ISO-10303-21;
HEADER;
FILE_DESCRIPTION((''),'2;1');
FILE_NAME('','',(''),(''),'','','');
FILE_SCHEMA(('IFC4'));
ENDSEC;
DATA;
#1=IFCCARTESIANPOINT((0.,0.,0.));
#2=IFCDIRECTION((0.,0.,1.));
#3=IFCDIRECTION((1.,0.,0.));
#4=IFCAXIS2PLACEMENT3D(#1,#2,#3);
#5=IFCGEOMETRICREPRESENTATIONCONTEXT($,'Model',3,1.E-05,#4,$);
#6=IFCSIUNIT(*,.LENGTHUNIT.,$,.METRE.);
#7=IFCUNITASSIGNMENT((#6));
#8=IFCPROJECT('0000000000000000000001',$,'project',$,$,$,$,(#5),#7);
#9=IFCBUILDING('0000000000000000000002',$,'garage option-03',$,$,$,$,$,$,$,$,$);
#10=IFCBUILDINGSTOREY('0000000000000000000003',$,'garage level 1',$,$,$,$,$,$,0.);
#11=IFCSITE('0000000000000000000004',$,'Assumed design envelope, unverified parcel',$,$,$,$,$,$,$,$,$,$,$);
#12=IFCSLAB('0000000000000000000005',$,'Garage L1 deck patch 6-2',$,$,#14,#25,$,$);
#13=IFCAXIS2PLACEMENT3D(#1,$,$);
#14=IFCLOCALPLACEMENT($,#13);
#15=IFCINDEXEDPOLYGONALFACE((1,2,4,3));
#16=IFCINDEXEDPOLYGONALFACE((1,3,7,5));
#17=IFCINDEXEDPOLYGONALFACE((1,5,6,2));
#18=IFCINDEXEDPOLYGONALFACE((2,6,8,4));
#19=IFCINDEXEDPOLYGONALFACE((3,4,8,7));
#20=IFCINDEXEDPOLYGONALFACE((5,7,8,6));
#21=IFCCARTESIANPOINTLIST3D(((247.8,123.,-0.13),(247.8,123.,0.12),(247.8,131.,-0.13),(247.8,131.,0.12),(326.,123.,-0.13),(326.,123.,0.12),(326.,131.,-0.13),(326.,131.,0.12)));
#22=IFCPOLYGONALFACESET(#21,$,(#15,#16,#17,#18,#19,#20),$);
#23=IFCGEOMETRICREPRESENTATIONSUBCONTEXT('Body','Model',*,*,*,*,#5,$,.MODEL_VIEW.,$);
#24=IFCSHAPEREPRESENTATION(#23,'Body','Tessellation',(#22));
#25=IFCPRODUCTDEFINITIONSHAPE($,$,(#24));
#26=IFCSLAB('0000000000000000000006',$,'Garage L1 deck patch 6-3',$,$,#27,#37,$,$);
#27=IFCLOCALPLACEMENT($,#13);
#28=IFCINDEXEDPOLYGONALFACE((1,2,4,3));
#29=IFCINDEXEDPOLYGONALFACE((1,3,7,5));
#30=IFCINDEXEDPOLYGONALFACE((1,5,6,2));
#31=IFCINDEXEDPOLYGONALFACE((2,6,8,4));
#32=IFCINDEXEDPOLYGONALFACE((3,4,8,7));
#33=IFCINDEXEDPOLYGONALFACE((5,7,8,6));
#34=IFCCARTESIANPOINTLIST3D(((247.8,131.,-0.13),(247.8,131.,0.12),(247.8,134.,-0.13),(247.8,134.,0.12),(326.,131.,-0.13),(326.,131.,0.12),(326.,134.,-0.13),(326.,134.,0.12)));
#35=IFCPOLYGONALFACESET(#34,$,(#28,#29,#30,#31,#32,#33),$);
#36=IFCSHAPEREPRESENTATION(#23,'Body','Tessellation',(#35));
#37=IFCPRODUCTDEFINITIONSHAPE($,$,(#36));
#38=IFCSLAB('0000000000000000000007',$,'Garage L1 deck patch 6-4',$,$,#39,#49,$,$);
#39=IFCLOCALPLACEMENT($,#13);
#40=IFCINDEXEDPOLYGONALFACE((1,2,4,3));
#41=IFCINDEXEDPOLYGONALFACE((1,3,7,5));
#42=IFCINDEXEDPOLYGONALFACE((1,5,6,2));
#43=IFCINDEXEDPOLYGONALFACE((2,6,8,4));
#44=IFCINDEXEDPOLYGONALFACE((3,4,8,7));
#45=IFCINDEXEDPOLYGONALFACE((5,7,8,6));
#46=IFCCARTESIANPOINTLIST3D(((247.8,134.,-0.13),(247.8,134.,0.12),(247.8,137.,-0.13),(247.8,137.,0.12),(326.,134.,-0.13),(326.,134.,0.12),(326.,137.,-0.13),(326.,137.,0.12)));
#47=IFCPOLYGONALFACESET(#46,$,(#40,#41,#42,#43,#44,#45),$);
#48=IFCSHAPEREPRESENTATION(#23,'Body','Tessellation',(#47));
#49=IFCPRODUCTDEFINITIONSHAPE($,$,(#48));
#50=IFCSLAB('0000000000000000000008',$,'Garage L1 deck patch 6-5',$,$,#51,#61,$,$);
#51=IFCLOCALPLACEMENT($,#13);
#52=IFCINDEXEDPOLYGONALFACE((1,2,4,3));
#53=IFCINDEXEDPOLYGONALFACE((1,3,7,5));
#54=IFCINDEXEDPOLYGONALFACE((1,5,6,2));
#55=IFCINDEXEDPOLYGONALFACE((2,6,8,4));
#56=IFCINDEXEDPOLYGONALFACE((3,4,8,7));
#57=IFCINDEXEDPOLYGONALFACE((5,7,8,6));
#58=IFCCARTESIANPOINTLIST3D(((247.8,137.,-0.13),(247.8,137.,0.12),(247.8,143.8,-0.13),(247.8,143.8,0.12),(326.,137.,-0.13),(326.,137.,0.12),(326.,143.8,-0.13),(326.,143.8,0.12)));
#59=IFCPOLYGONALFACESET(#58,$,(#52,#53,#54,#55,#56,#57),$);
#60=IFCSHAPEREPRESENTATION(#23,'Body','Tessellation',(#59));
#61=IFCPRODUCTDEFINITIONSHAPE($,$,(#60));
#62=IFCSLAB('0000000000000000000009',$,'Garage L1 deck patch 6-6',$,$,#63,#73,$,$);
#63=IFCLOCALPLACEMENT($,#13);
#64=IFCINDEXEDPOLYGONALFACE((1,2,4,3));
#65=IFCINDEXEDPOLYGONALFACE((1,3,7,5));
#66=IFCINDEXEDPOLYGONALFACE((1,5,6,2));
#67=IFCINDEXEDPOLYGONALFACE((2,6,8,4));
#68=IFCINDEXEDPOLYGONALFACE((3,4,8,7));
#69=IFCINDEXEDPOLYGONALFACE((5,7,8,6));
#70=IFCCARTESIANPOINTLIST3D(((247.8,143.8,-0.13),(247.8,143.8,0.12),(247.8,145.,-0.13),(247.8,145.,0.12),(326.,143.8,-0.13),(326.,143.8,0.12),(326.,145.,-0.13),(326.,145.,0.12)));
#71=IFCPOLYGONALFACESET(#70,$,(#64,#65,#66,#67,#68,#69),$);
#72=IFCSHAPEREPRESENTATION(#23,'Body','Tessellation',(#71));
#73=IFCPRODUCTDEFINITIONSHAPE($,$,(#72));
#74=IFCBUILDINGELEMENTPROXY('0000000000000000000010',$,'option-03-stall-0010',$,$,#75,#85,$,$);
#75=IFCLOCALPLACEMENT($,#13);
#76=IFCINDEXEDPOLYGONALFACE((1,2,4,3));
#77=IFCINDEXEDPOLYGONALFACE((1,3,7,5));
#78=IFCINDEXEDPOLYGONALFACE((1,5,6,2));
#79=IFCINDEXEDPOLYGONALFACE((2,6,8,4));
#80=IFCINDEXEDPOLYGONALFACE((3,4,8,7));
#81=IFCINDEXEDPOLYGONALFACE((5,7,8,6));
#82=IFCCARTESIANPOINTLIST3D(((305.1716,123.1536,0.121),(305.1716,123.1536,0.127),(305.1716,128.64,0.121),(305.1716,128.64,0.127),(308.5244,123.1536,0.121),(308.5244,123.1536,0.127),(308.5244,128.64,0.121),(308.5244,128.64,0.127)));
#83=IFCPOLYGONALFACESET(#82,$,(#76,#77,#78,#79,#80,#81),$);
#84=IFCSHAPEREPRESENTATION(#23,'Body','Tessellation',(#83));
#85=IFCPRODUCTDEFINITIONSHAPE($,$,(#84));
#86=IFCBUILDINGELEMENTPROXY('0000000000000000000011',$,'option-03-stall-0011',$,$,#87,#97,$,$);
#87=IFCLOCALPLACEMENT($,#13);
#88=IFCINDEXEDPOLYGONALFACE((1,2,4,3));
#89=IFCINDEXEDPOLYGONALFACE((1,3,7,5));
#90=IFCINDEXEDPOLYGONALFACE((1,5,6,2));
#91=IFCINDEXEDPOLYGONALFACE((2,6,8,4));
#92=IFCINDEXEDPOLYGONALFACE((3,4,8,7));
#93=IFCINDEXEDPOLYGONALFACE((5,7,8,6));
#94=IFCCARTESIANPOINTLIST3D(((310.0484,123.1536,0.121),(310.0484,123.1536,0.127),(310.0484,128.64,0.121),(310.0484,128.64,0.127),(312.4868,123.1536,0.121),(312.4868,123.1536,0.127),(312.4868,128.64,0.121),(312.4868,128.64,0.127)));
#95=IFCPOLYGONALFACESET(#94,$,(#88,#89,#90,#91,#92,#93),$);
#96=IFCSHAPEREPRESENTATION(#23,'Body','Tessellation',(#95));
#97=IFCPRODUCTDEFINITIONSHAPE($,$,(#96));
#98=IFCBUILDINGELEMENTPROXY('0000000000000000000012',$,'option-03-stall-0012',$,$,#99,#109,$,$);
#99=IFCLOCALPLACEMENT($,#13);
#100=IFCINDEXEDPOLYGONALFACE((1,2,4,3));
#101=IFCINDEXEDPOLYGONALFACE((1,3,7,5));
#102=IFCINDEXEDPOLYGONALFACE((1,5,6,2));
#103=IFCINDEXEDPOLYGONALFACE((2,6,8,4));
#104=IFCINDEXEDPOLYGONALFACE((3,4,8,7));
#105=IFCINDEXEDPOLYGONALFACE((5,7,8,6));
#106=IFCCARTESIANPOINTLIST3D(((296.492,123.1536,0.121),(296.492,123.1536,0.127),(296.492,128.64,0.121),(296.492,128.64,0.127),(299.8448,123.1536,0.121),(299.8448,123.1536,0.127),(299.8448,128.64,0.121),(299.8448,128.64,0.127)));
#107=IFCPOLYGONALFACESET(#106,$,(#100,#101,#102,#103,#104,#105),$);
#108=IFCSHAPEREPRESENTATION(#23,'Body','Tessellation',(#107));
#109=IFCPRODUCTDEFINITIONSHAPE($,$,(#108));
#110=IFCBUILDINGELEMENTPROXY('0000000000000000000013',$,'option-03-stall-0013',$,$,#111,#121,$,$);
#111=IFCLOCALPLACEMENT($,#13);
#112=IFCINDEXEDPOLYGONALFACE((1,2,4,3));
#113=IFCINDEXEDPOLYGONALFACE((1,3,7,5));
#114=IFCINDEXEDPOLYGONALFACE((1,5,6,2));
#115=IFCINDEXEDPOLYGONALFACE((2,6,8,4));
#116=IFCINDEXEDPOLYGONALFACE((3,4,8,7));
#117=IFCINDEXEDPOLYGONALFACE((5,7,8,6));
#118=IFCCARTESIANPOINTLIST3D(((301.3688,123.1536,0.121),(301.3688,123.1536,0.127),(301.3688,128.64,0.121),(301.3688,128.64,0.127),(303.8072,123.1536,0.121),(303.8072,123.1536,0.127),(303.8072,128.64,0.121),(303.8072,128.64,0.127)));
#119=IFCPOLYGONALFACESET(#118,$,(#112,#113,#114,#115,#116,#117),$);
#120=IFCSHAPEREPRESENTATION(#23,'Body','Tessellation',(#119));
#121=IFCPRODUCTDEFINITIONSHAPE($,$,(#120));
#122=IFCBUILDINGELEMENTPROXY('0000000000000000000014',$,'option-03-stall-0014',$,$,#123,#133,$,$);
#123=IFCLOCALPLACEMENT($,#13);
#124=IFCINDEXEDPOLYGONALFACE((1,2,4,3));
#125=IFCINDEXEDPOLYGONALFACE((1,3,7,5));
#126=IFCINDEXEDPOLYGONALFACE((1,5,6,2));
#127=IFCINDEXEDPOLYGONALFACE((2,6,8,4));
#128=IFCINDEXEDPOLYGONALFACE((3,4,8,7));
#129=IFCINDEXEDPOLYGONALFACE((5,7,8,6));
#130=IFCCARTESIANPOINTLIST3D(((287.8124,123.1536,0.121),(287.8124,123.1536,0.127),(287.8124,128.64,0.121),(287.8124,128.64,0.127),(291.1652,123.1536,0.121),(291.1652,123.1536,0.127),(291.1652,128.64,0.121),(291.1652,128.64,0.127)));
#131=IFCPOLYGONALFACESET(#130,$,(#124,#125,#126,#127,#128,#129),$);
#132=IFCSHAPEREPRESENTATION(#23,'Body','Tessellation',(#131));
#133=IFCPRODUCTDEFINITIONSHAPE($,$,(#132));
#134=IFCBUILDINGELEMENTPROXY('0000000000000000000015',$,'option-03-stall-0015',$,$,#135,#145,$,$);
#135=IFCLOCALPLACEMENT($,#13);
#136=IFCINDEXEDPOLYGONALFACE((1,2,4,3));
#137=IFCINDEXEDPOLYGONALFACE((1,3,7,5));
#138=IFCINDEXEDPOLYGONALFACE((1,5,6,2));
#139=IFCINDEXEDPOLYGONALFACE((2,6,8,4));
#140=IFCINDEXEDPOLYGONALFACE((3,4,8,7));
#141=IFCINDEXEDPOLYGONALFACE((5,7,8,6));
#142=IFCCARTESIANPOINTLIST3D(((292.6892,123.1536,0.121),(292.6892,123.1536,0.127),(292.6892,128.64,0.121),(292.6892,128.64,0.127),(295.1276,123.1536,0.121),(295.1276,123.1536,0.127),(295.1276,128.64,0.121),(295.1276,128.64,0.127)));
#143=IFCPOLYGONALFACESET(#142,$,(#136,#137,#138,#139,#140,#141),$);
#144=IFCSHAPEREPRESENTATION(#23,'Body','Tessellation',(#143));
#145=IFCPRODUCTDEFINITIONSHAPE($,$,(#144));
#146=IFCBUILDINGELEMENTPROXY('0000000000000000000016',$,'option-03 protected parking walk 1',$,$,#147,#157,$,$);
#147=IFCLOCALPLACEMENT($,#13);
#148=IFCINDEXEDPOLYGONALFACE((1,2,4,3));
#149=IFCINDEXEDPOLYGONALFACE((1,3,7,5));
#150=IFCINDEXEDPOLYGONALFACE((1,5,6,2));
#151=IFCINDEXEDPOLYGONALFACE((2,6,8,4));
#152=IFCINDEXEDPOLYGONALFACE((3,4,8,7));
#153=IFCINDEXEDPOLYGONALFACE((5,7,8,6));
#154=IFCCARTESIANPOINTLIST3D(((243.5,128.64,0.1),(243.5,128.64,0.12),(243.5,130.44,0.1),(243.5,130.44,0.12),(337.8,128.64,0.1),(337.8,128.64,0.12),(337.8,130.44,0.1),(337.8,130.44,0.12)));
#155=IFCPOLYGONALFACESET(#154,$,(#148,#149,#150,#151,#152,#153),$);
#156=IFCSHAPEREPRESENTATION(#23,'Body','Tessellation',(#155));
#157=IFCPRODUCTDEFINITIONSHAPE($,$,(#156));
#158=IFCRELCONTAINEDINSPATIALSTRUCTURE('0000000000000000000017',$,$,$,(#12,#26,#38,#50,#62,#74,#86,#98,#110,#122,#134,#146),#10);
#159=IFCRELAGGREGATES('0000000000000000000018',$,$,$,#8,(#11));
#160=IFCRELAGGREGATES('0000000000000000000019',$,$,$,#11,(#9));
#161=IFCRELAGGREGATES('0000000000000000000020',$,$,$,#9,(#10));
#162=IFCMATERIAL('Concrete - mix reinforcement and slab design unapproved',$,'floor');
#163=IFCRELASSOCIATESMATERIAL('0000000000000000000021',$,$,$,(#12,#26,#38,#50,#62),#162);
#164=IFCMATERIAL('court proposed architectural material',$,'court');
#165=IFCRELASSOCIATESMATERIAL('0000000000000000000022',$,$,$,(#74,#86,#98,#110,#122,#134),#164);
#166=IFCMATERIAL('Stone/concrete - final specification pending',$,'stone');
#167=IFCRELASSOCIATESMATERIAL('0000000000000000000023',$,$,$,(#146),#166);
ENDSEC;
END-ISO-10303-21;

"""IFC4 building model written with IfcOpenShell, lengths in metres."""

from ifc_helpers import new_model, si_unit, frame, origin_with_axes, place, context, subcontext, project, spatial, rectangle, extrude, material, element, save


model = new_model("IFC4")

# Units and contexts
model_context = context("Model", 3, precision=1e-05, world=origin_with_axes())
body_context = subcontext(model_context, "Body", "Model", "MODEL_VIEW")
ifc_project = project(units=[si_unit("LENGTHUNIT", "METRE")], contexts=[model_context])

# Site, building, storey
site = spatial("IfcSite", under=ifc_project, Name="Assumed design envelope, unverified parcel")
building = spatial("IfcBuilding", under=site, Name="garage option-03")
storey = spatial("IfcBuildingStorey", under=building, Name="garage level 1", Elevation=0.0)

# Shared definitions
ifc_material_1 = material(Name="Concrete - mix reinforcement and slab design unapproved", Category="floor")

# Slabs
slab_1_placement = place(None, frame((286.9, 127.0, -0.13), z_axis=(0.0, 0.0, 1.0), x_axis=(1.0, 0.0, 0.0)))
element("IfcSlab", 1, at=slab_1_placement, inside=storey, material=ifc_material_1, Name="Garage L1 deck patch 6-2", context=body_context, shape_type="SweptSolid", body=[
    extrude(rectangle(XDim=78.2, YDim=8.0), origin_with_axes(), (0.0, 0.0, 1.0), 0.25),
])
for number, where, z_axis, x_axis, name in (
    (2, (286.9, 132.5, -0.13), (0.0, 0.0, 1.0), (1.0, 0.0, 0.0), "Garage L1 deck patch 6-3"),
    (3, (286.9, 135.5, -0.13), (0.0, 0.0, 1.0), (1.0, 0.0, 0.0), "Garage L1 deck patch 6-4"),
):
    element("IfcSlab", number, at=place(None, frame(where, z_axis=z_axis, x_axis=x_axis)), inside=storey, material=ifc_material_1, Name=name, context=body_context, shape_type="SweptSolid", body=[
        extrude(rectangle(XDim=78.2, YDim=3.0), origin_with_axes(), (0.0, 0.0, 1.0), 0.25),
    ])
slab_2_placement = place(None, frame((286.9, 140.4, -0.13), z_axis=(0.0, 0.0, 1.0), x_axis=(1.0, 0.0, 0.0)))
element("IfcSlab", 4, at=slab_2_placement, inside=storey, material=ifc_material_1, Name="Garage L1 deck patch 6-5", context=body_context, shape_type="SweptSolid", body=[
    extrude(rectangle(XDim=78.2, YDim=6.8), origin_with_axes(), (0.0, 0.0, 1.0), 0.25),
])
slab_3_placement = place(None, frame((286.9, 144.4, -0.13), z_axis=(0.0, 0.0, 1.0), x_axis=(1.0, 0.0, 0.0)))
element("IfcSlab", 5, at=slab_3_placement, inside=storey, material=ifc_material_1, Name="Garage L1 deck patch 6-6", context=body_context, shape_type="SweptSolid", body=[
    extrude(rectangle(XDim=78.2, YDim=1.2), origin_with_axes(), (0.0, 0.0, 1.0), 0.25),
])

# Building element proxies
ifc_material_2 = material(Name="court proposed architectural material", Category="court")
proxy_1_placement = place(None, frame((306.848, 125.8968, 0.121), z_axis=(0.0, 0.0, 1.0), x_axis=(1.0, 0.0, 0.0)))
element("IfcBuildingElementProxy", 6, at=proxy_1_placement, inside=storey, material=ifc_material_2, Name="option-03-stall-0010", context=body_context, shape_type="SweptSolid", body=[
    extrude(rectangle(XDim=3.3528, YDim=5.4864), origin_with_axes(), (0.0, 0.0, 1.0), 0.006),
])
proxy_2_placement = place(None, frame((311.2676, 125.8968, 0.121), z_axis=(0.0, 0.0, 1.0), x_axis=(1.0, 0.0, 0.0)))
element("IfcBuildingElementProxy", 7, at=proxy_2_placement, inside=storey, material=ifc_material_2, Name="option-03-stall-0011", context=body_context, shape_type="SweptSolid", body=[
    extrude(rectangle(XDim=2.4384, YDim=5.4864), origin_with_axes(), (0.0, 0.0, 1.0), 0.006),
])
proxy_3_placement = place(None, frame((298.1684, 125.8968, 0.121), z_axis=(0.0, 0.0, 1.0), x_axis=(1.0, 0.0, 0.0)))
element("IfcBuildingElementProxy", 8, at=proxy_3_placement, inside=storey, material=ifc_material_2, Name="option-03-stall-0012", context=body_context, shape_type="SweptSolid", body=[
    extrude(rectangle(XDim=3.3528, YDim=5.4864), origin_with_axes(), (0.0, 0.0, 1.0), 0.006),
])
proxy_4_placement = place(None, frame((302.588, 125.8968, 0.121), z_axis=(0.0, 0.0, 1.0), x_axis=(1.0, 0.0, 0.0)))
element("IfcBuildingElementProxy", 9, at=proxy_4_placement, inside=storey, material=ifc_material_2, Name="option-03-stall-0013", context=body_context, shape_type="SweptSolid", body=[
    extrude(rectangle(XDim=2.4384, YDim=5.4864), origin_with_axes(), (0.0, 0.0, 1.0), 0.006),
])
proxy_5_placement = place(None, frame((289.4888, 125.8968, 0.121), z_axis=(0.0, 0.0, 1.0), x_axis=(1.0, 0.0, 0.0)))
element("IfcBuildingElementProxy", 10, at=proxy_5_placement, inside=storey, material=ifc_material_2, Name="option-03-stall-0014", context=body_context, shape_type="SweptSolid", body=[
    extrude(rectangle(XDim=3.3528, YDim=5.4864), origin_with_axes(), (0.0, 0.0, 1.0), 0.006),
])
proxy_6_placement = place(None, frame((293.9084, 125.8968, 0.121), z_axis=(0.0, 0.0, 1.0), x_axis=(1.0, 0.0, 0.0)))
element("IfcBuildingElementProxy", 11, at=proxy_6_placement, inside=storey, material=ifc_material_2, Name="option-03-stall-0015", context=body_context, shape_type="SweptSolid", body=[
    extrude(rectangle(XDim=2.4384, YDim=5.4864), origin_with_axes(), (0.0, 0.0, 1.0), 0.006),
])
ifc_material_3 = material(Name="Stone/concrete - final specification pending", Category="stone")
proxy_7_placement = place(None, frame((290.65, 129.54, 0.1), z_axis=(0.0, 0.0, 1.0), x_axis=(1.0, 0.0, 0.0)))
element("IfcBuildingElementProxy", 12, at=proxy_7_placement, inside=storey, material=ifc_material_3, Name="option-03 protected parking walk 1", context=body_context, shape_type="SweptSolid", body=[
    extrude(rectangle(XDim=94.3, YDim=1.8), origin_with_axes(), (0.0, 0.0, 1.0), 0.02),
])

save(model, "model.ifc")
